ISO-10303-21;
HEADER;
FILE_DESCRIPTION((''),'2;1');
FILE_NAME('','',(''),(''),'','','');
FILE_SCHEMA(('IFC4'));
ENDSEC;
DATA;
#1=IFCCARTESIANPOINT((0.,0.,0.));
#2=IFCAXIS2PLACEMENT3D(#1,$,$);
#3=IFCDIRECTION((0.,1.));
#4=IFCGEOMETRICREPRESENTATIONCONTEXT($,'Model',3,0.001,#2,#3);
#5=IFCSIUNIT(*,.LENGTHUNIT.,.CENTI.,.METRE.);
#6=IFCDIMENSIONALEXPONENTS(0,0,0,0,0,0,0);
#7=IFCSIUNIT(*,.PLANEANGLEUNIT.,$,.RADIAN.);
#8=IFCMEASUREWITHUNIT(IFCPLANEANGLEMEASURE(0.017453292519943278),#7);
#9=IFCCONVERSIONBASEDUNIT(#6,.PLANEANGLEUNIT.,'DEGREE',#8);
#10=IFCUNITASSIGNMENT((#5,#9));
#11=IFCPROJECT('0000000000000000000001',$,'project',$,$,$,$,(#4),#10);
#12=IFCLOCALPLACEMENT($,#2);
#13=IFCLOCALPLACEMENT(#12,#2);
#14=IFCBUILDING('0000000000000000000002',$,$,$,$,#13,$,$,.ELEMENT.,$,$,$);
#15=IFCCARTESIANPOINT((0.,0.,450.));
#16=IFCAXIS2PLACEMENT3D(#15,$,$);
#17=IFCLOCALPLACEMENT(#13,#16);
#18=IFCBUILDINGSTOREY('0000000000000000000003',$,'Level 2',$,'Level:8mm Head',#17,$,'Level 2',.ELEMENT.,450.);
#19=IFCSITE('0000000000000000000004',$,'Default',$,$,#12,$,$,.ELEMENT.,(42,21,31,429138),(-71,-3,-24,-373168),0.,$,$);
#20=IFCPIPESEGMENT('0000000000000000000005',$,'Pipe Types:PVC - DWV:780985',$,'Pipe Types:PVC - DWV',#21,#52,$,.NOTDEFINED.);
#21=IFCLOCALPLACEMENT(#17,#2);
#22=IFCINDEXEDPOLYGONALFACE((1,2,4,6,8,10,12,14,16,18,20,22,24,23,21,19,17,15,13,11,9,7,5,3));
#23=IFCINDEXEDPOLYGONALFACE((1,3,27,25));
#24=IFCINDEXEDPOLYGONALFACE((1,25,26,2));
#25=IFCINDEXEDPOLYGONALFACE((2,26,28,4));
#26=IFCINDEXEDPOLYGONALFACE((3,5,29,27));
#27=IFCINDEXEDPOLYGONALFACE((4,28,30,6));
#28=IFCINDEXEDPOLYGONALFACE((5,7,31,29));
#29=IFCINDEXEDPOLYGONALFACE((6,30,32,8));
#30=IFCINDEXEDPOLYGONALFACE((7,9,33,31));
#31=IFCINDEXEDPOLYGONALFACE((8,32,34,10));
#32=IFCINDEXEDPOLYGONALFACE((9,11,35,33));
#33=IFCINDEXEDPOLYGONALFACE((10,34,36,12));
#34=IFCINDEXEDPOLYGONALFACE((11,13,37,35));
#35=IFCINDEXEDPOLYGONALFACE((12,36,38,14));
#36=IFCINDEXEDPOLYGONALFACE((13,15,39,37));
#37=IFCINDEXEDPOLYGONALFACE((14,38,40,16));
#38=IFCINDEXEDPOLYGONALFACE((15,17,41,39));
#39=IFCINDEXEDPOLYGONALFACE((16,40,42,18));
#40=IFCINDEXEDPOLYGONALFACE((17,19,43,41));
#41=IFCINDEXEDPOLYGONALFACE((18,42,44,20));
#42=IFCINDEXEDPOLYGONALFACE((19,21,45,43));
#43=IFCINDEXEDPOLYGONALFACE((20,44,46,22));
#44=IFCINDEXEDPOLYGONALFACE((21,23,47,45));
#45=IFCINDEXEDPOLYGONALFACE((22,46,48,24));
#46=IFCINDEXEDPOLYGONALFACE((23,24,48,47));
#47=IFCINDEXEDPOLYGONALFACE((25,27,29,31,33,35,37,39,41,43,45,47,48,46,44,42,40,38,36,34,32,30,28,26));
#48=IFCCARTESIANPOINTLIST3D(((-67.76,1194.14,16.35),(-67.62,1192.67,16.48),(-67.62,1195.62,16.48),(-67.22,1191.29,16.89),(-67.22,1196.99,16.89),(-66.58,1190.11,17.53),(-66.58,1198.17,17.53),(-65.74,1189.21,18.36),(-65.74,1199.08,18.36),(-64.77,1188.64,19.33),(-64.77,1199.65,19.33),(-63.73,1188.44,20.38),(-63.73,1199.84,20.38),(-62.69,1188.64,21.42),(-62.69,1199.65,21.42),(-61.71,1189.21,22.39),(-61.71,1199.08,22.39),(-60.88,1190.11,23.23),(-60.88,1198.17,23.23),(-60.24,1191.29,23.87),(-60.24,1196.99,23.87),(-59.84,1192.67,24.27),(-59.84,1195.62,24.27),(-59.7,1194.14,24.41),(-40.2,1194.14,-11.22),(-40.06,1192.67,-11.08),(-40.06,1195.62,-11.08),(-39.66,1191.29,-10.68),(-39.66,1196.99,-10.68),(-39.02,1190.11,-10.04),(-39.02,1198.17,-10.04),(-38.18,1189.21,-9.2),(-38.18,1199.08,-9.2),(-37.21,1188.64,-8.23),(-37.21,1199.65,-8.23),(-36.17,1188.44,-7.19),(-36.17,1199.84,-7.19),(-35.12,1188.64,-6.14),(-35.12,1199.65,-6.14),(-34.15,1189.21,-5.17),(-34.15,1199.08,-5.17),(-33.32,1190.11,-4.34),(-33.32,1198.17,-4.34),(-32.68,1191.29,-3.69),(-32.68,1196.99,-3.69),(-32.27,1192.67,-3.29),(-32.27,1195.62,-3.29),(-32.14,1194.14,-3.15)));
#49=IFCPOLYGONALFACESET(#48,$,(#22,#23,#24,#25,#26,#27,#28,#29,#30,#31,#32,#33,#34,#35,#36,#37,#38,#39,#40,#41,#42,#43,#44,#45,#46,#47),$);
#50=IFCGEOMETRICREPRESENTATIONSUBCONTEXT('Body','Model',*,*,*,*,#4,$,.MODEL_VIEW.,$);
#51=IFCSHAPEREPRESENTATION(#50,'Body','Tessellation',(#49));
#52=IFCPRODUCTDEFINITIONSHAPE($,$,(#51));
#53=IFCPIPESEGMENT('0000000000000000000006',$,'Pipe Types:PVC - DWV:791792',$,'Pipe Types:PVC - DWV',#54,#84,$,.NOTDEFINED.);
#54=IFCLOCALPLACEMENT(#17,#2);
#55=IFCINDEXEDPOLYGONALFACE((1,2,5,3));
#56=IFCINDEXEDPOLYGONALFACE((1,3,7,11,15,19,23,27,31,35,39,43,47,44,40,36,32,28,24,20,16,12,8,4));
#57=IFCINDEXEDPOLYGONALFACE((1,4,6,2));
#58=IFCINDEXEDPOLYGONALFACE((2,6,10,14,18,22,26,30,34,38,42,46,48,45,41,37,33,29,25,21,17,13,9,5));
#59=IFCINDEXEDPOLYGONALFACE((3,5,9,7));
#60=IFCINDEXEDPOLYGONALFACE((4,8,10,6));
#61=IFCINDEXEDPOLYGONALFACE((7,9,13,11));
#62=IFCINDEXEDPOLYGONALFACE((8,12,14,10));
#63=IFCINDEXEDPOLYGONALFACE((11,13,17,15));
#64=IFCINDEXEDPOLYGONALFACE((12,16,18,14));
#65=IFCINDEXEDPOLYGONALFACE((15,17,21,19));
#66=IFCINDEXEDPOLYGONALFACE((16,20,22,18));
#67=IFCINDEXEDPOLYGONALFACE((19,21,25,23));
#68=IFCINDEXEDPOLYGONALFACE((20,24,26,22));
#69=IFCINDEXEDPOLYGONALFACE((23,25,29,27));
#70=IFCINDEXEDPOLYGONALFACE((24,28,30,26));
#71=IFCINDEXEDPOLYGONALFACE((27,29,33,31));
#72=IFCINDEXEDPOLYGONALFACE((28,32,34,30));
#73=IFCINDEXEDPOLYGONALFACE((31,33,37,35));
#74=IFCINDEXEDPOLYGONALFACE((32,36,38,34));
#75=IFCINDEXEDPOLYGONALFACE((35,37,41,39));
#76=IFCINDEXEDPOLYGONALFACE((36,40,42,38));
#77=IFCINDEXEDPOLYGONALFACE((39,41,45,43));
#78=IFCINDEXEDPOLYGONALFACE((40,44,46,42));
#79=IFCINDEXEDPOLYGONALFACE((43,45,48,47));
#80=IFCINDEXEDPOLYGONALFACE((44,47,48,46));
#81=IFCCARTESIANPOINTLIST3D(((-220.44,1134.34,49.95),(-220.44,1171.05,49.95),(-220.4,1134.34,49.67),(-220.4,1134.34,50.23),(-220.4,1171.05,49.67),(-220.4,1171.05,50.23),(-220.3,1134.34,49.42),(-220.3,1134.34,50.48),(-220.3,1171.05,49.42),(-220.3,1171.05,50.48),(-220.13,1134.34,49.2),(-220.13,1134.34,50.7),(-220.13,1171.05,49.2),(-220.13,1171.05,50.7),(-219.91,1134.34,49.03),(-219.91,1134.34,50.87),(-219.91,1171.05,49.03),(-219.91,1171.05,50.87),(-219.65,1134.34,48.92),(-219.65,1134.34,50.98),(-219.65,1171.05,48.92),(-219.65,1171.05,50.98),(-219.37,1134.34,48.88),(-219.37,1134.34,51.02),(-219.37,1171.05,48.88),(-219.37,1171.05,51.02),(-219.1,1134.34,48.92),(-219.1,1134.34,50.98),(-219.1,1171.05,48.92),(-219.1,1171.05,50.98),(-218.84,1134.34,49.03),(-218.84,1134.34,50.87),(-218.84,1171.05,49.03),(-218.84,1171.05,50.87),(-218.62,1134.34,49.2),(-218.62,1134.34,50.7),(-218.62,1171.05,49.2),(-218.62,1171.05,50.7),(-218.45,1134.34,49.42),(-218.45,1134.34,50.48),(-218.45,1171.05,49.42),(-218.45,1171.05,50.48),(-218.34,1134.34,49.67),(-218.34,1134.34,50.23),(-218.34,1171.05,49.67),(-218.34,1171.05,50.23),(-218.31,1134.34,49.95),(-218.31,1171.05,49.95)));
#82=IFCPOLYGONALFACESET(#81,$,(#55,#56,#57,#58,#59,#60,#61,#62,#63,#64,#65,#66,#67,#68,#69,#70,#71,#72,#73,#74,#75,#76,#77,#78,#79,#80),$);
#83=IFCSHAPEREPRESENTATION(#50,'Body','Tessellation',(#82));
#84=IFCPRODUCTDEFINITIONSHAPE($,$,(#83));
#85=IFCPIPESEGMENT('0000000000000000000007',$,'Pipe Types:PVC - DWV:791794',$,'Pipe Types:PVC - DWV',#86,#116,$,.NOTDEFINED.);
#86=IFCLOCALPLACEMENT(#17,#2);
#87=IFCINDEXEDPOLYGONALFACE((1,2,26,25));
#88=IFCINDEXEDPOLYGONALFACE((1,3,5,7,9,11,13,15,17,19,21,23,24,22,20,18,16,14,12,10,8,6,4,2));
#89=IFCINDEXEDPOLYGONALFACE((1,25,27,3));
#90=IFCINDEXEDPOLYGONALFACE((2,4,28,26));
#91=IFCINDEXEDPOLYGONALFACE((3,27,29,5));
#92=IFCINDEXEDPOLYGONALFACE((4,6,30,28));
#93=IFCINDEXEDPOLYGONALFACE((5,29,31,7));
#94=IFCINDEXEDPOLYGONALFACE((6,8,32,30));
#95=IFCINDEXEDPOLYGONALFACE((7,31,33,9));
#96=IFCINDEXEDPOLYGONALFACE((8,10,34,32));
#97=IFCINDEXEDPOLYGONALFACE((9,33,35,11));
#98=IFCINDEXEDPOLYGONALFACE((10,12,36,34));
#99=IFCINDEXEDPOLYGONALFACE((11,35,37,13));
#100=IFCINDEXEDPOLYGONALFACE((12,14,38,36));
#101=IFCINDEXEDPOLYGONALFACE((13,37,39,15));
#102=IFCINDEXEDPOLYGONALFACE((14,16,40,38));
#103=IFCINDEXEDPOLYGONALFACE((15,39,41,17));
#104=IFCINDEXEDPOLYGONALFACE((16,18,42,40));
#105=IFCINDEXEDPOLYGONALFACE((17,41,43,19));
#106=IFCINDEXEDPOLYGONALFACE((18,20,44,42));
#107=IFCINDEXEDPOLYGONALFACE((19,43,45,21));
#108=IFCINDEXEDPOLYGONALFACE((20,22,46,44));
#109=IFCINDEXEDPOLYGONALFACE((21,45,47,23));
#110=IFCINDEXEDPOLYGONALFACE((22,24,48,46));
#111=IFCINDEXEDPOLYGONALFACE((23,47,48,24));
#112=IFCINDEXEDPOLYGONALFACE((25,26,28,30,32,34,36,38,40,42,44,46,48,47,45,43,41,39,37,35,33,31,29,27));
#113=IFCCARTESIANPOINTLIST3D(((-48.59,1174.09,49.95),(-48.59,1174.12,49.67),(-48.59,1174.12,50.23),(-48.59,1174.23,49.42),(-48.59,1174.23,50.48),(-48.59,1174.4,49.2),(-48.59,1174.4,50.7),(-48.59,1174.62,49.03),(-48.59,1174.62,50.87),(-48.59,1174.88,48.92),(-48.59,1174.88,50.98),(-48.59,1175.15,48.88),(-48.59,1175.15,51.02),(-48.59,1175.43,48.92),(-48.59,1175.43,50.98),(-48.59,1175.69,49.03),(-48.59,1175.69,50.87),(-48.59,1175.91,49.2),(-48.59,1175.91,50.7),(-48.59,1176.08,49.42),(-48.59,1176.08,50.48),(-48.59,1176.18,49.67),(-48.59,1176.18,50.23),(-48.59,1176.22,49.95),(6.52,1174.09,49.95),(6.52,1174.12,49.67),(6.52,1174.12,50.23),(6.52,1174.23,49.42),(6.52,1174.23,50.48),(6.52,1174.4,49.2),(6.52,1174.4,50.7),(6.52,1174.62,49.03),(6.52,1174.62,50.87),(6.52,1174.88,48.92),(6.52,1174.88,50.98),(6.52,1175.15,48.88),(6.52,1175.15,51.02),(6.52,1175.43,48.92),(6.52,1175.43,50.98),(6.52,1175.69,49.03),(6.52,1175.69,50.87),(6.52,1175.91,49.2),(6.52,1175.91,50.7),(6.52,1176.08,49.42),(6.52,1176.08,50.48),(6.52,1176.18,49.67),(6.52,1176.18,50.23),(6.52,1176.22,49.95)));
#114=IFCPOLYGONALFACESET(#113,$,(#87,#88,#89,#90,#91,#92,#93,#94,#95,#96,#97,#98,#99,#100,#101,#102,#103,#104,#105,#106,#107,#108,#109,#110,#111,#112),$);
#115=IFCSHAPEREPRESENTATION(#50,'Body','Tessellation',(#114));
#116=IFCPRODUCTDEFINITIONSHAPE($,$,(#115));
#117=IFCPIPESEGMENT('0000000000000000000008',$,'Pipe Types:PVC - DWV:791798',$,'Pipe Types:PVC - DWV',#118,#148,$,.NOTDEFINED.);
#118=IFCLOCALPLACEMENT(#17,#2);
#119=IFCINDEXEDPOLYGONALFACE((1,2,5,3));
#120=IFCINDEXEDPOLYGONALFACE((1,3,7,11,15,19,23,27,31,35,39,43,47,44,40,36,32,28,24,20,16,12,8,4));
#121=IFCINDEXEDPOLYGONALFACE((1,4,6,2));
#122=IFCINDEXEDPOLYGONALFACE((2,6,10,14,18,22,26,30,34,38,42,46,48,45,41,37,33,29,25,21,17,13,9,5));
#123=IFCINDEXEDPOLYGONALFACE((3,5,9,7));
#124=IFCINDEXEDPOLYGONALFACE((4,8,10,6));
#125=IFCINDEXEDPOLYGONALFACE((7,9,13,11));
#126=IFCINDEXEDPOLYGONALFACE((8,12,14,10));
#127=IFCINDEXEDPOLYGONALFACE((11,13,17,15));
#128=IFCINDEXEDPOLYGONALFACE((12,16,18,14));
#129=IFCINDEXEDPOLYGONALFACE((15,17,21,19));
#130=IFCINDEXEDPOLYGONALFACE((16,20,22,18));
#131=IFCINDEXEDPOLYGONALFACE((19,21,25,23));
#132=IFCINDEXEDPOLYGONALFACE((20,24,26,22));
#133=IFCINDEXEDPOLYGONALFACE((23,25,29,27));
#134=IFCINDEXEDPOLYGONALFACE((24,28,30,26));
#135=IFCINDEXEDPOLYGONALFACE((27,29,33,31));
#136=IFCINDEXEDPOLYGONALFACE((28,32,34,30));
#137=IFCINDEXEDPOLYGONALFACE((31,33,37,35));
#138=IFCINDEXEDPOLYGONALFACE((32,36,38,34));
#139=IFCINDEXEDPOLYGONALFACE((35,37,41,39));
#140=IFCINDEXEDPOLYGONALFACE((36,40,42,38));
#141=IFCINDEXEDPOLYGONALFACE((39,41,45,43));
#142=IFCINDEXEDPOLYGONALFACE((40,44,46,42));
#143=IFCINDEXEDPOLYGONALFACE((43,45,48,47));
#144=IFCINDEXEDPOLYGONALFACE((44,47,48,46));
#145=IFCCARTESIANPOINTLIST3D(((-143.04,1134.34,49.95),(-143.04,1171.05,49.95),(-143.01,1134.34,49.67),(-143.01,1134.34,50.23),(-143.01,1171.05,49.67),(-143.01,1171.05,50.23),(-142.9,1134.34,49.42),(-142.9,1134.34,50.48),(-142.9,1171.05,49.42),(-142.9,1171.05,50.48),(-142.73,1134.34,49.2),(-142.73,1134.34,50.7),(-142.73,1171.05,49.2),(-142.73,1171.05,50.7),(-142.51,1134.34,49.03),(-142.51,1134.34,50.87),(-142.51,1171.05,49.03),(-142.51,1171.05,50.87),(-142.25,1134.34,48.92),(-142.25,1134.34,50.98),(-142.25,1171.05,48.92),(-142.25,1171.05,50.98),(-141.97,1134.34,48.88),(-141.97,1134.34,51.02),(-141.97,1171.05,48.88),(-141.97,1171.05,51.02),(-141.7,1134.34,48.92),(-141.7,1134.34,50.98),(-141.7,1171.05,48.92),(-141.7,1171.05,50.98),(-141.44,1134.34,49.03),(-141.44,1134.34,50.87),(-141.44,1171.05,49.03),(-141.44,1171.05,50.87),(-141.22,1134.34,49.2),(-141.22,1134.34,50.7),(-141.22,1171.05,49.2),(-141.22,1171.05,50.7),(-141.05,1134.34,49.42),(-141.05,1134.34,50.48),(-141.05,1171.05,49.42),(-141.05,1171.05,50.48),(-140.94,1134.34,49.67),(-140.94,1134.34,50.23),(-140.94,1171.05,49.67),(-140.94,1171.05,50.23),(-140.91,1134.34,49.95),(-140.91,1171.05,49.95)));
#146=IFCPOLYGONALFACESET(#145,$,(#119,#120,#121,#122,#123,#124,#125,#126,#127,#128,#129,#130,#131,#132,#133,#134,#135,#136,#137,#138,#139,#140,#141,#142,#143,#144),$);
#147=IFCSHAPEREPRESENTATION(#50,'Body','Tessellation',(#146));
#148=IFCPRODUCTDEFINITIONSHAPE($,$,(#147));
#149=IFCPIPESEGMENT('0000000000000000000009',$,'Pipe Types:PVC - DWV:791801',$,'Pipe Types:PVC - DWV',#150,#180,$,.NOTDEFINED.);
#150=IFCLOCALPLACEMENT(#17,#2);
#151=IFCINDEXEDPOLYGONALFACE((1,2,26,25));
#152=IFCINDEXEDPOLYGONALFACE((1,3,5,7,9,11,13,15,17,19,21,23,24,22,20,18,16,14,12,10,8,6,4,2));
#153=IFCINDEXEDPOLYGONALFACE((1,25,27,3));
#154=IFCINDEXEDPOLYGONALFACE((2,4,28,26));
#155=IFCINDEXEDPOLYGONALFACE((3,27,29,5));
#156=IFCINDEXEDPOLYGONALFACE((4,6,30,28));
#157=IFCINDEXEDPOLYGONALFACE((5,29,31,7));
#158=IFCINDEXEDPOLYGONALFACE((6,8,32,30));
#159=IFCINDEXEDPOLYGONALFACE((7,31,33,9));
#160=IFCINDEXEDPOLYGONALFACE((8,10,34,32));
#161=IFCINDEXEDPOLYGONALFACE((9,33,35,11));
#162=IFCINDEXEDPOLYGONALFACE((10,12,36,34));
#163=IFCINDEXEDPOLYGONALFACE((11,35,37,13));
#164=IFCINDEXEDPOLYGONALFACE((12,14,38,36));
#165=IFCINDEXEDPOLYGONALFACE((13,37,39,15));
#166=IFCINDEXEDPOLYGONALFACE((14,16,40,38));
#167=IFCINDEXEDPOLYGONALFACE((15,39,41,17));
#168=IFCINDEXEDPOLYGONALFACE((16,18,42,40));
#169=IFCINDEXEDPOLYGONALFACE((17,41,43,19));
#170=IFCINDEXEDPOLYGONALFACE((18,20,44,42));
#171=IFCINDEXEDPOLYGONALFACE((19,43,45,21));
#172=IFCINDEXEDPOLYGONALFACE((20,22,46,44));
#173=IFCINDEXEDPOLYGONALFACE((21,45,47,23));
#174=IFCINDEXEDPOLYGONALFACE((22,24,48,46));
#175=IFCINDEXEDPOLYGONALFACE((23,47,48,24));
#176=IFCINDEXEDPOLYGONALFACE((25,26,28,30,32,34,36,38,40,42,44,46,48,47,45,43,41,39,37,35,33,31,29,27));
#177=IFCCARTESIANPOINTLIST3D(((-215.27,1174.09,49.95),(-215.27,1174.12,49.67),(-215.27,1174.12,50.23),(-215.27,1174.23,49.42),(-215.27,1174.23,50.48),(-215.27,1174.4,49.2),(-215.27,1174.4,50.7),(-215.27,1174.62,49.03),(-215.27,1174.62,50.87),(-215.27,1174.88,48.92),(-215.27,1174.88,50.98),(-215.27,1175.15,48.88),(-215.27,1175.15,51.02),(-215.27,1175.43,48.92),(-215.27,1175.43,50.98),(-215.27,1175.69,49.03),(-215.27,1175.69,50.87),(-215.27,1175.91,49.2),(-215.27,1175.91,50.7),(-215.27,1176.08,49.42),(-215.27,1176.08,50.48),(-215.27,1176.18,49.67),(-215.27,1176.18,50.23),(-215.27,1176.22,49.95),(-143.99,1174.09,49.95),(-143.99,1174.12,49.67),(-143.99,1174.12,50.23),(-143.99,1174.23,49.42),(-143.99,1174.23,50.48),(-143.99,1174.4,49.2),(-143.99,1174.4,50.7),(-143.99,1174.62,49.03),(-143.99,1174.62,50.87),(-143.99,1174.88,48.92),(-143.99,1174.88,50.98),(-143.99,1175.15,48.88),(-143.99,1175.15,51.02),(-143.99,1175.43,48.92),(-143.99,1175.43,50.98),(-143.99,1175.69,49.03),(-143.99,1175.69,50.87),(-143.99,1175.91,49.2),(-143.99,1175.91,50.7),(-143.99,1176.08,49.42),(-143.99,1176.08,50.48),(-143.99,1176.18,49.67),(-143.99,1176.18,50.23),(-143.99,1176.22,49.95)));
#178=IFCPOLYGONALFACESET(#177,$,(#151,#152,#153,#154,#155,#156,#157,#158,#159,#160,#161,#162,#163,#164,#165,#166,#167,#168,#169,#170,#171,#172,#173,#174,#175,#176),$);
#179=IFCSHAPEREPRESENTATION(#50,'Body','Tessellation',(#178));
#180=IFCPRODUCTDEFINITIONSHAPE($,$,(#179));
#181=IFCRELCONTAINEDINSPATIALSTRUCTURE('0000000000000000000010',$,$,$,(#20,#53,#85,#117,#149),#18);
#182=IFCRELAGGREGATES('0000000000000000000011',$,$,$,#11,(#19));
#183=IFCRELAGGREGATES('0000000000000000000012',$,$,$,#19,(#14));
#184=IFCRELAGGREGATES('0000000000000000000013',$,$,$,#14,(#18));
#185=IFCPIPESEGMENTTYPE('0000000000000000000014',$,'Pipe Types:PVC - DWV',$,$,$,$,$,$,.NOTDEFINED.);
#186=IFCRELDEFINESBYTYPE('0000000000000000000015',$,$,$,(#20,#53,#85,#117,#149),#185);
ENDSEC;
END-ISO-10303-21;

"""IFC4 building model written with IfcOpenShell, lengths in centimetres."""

from ifc_helpers import new_model, entity, si_unit, converted_unit, direction, frame, origin, place, context, subcontext, project, spatial, arc, indexed_curve, outline, extrude, type_object, element, save


model = new_model("IFC4")

# Units and contexts
model_context = context("Model", 3, precision=0.001, world=origin(), true_north=direction((0.0, 1.0)))
body_context = subcontext(model_context, "Body", "Model", "MODEL_VIEW")
ifc_project = project(units=[si_unit("LENGTHUNIT", "METRE", prefix="CENTI"), converted_unit("PLANEANGLEUNIT", "DEGREE", entity("IfcPlaneAngleMeasure", 0.017453292519943278), si_unit("PLANEANGLEUNIT", "RADIAN"), dimensions=[0, 0, 0, 0, 0, 0, 0])], contexts=[model_context])

# Site, building, storey
site_placement = place(None, origin())
site = spatial("IfcSite", under=ifc_project, at=site_placement, Name="Default", CompositionType="ELEMENT", RefLatitude=(42, 21, 31, 429138), RefLongitude=(-71, -3, -24, -373168), RefElevation=0.0)
building_placement = place(site_placement, origin())
building = spatial("IfcBuilding", under=site, at=building_placement, CompositionType="ELEMENT")
storey_placement = place(building_placement, frame((0.0, 0.0, 450.0)))
storey = spatial("IfcBuildingStorey", under=building, at=storey_placement, Name="Level 2", ObjectType="Level:8mm Head", LongName="Level 2", CompositionType="ELEMENT", Elevation=450.0)

# Pipe segments
pipe_segment_type = type_object("IfcPipeSegmentType", Name="Pipe Types:PVC - DWV", PredefinedType="NOTDEFINED")
pipe_segment_1_placement = place(storey_placement, origin())
element("IfcPipeSegment", 1, at=pipe_segment_1_placement, inside=storey, type_object=pipe_segment_type, Name="Pipe Types:PVC - DWV:780985", ObjectType="Pipe Types:PVC - DWV", PredefinedType="NOTDEFINED", context=body_context, shape_type="SweptSolid", body=[
    extrude(outline(indexed_curve([(5.7, 0.0), (4.03, 4.03), (0.0, 5.7), (-4.03, 4.03), (-5.7, 0.0), (-4.03, -4.03), (0.0, -5.7), (4.03, -4.03)], segments=[arc(1, 2, 3), arc(3, 4, 5), arc(5, 6, 7), arc(7, 8, 1)], self_intersect=False)), frame((-63.73, 1194.14, 20.38), z_axis=(0.707107, 0.0, -0.707107), x_axis=(0.0, -1.0, 0.0)), (0.0, 0.0, 1.0), 38.98),
])
pipe_segment_2_placement = place(storey_placement, origin())
element("IfcPipeSegment", 2, at=pipe_segment_2_placement, inside=storey, type_object=pipe_segment_type, Name="Pipe Types:PVC - DWV:791792", ObjectType="Pipe Types:PVC - DWV", PredefinedType="NOTDEFINED", context=body_context, shape_type="SweptSolid", body=[
    extrude(outline(indexed_curve([(1.07, 0.0), (0.75, 0.75), (0.0, 1.07), (-0.75, 0.75), (-1.07, 0.0), (-0.75, -0.75), (0.0, -1.07), (0.75, -0.75)], segments=[arc(1, 2, 3), arc(3, 4, 5), arc(5, 6, 7), arc(7, 8, 1)], self_intersect=False)), frame((-219.37, 1134.34, 49.95), z_axis=(0.0, 1.0, 0.0), x_axis=(1.0, 0.0, 0.0)), (0.0, 0.0, 1.0), 36.71),
])
pipe_segment_3_placement = place(storey_placement, origin())
element("IfcPipeSegment", 3, at=pipe_segment_3_placement, inside=storey, type_object=pipe_segment_type, Name="Pipe Types:PVC - DWV:791794", ObjectType="Pipe Types:PVC - DWV", PredefinedType="NOTDEFINED", context=body_context, shape_type="SweptSolid", body=[
    extrude(outline(indexed_curve([(1.07, 0.0), (0.75, 0.75), (0.0, 1.07), (-0.75, 0.75), (-1.07, 0.0), (-0.75, -0.75), (0.0, -1.07), (0.75, -0.75)], segments=[arc(1, 2, 3), arc(3, 4, 5), arc(5, 6, 7), arc(7, 8, 1)], self_intersect=False)), frame((-48.59, 1175.15, 49.95), z_axis=(1.0, 0.0, 0.0), x_axis=(0.0, -1.0, 0.0)), (0.0, 0.0, 1.0), 55.11),
])
pipe_segment_4_placement = place(storey_placement, origin())
element("IfcPipeSegment", 4, at=pipe_segment_4_placement, inside=storey, type_object=pipe_segment_type, Name="Pipe Types:PVC - DWV:791798", ObjectType="Pipe Types:PVC - DWV", PredefinedType="NOTDEFINED", context=body_context, shape_type="SweptSolid", body=[
    extrude(outline(indexed_curve([(1.07, 0.0), (0.75, 0.75), (0.0, 1.07), (-0.75, 0.75), (-1.07, 0.0), (-0.75, -0.75), (0.0, -1.07), (0.75, -0.75)], segments=[arc(1, 2, 3), arc(3, 4, 5), arc(5, 6, 7), arc(7, 8, 1)], self_intersect=False)), frame((-141.97, 1134.34, 49.95), z_axis=(0.0, 1.0, 0.0), x_axis=(-1.0, 0.0, 0.0)), (0.0, 0.0, 1.0), 36.71),
])
pipe_segment_5_placement = place(storey_placement, origin())
element("IfcPipeSegment", 5, at=pipe_segment_5_placement, inside=storey, type_object=pipe_segment_type, Name="Pipe Types:PVC - DWV:791801", ObjectType="Pipe Types:PVC - DWV", PredefinedType="NOTDEFINED", context=body_context, shape_type="SweptSolid", body=[
    extrude(outline(indexed_curve([(1.07, 0.0), (0.75, 0.75), (0.0, 1.07), (-0.75, 0.75), (-1.07, 0.0), (-0.75, -0.75), (0.0, -1.07), (0.75, -0.75)], segments=[arc(1, 2, 3), arc(3, 4, 5), arc(5, 6, 7), arc(7, 8, 1)], self_intersect=False)), frame((-215.27, 1175.15, 49.95), z_axis=(1.0, 0.0, 0.0), x_axis=(0.0, -1.0, 0.0)), (0.0, 0.0, 1.0), 71.29),
])

save(model, "model.ifc")
